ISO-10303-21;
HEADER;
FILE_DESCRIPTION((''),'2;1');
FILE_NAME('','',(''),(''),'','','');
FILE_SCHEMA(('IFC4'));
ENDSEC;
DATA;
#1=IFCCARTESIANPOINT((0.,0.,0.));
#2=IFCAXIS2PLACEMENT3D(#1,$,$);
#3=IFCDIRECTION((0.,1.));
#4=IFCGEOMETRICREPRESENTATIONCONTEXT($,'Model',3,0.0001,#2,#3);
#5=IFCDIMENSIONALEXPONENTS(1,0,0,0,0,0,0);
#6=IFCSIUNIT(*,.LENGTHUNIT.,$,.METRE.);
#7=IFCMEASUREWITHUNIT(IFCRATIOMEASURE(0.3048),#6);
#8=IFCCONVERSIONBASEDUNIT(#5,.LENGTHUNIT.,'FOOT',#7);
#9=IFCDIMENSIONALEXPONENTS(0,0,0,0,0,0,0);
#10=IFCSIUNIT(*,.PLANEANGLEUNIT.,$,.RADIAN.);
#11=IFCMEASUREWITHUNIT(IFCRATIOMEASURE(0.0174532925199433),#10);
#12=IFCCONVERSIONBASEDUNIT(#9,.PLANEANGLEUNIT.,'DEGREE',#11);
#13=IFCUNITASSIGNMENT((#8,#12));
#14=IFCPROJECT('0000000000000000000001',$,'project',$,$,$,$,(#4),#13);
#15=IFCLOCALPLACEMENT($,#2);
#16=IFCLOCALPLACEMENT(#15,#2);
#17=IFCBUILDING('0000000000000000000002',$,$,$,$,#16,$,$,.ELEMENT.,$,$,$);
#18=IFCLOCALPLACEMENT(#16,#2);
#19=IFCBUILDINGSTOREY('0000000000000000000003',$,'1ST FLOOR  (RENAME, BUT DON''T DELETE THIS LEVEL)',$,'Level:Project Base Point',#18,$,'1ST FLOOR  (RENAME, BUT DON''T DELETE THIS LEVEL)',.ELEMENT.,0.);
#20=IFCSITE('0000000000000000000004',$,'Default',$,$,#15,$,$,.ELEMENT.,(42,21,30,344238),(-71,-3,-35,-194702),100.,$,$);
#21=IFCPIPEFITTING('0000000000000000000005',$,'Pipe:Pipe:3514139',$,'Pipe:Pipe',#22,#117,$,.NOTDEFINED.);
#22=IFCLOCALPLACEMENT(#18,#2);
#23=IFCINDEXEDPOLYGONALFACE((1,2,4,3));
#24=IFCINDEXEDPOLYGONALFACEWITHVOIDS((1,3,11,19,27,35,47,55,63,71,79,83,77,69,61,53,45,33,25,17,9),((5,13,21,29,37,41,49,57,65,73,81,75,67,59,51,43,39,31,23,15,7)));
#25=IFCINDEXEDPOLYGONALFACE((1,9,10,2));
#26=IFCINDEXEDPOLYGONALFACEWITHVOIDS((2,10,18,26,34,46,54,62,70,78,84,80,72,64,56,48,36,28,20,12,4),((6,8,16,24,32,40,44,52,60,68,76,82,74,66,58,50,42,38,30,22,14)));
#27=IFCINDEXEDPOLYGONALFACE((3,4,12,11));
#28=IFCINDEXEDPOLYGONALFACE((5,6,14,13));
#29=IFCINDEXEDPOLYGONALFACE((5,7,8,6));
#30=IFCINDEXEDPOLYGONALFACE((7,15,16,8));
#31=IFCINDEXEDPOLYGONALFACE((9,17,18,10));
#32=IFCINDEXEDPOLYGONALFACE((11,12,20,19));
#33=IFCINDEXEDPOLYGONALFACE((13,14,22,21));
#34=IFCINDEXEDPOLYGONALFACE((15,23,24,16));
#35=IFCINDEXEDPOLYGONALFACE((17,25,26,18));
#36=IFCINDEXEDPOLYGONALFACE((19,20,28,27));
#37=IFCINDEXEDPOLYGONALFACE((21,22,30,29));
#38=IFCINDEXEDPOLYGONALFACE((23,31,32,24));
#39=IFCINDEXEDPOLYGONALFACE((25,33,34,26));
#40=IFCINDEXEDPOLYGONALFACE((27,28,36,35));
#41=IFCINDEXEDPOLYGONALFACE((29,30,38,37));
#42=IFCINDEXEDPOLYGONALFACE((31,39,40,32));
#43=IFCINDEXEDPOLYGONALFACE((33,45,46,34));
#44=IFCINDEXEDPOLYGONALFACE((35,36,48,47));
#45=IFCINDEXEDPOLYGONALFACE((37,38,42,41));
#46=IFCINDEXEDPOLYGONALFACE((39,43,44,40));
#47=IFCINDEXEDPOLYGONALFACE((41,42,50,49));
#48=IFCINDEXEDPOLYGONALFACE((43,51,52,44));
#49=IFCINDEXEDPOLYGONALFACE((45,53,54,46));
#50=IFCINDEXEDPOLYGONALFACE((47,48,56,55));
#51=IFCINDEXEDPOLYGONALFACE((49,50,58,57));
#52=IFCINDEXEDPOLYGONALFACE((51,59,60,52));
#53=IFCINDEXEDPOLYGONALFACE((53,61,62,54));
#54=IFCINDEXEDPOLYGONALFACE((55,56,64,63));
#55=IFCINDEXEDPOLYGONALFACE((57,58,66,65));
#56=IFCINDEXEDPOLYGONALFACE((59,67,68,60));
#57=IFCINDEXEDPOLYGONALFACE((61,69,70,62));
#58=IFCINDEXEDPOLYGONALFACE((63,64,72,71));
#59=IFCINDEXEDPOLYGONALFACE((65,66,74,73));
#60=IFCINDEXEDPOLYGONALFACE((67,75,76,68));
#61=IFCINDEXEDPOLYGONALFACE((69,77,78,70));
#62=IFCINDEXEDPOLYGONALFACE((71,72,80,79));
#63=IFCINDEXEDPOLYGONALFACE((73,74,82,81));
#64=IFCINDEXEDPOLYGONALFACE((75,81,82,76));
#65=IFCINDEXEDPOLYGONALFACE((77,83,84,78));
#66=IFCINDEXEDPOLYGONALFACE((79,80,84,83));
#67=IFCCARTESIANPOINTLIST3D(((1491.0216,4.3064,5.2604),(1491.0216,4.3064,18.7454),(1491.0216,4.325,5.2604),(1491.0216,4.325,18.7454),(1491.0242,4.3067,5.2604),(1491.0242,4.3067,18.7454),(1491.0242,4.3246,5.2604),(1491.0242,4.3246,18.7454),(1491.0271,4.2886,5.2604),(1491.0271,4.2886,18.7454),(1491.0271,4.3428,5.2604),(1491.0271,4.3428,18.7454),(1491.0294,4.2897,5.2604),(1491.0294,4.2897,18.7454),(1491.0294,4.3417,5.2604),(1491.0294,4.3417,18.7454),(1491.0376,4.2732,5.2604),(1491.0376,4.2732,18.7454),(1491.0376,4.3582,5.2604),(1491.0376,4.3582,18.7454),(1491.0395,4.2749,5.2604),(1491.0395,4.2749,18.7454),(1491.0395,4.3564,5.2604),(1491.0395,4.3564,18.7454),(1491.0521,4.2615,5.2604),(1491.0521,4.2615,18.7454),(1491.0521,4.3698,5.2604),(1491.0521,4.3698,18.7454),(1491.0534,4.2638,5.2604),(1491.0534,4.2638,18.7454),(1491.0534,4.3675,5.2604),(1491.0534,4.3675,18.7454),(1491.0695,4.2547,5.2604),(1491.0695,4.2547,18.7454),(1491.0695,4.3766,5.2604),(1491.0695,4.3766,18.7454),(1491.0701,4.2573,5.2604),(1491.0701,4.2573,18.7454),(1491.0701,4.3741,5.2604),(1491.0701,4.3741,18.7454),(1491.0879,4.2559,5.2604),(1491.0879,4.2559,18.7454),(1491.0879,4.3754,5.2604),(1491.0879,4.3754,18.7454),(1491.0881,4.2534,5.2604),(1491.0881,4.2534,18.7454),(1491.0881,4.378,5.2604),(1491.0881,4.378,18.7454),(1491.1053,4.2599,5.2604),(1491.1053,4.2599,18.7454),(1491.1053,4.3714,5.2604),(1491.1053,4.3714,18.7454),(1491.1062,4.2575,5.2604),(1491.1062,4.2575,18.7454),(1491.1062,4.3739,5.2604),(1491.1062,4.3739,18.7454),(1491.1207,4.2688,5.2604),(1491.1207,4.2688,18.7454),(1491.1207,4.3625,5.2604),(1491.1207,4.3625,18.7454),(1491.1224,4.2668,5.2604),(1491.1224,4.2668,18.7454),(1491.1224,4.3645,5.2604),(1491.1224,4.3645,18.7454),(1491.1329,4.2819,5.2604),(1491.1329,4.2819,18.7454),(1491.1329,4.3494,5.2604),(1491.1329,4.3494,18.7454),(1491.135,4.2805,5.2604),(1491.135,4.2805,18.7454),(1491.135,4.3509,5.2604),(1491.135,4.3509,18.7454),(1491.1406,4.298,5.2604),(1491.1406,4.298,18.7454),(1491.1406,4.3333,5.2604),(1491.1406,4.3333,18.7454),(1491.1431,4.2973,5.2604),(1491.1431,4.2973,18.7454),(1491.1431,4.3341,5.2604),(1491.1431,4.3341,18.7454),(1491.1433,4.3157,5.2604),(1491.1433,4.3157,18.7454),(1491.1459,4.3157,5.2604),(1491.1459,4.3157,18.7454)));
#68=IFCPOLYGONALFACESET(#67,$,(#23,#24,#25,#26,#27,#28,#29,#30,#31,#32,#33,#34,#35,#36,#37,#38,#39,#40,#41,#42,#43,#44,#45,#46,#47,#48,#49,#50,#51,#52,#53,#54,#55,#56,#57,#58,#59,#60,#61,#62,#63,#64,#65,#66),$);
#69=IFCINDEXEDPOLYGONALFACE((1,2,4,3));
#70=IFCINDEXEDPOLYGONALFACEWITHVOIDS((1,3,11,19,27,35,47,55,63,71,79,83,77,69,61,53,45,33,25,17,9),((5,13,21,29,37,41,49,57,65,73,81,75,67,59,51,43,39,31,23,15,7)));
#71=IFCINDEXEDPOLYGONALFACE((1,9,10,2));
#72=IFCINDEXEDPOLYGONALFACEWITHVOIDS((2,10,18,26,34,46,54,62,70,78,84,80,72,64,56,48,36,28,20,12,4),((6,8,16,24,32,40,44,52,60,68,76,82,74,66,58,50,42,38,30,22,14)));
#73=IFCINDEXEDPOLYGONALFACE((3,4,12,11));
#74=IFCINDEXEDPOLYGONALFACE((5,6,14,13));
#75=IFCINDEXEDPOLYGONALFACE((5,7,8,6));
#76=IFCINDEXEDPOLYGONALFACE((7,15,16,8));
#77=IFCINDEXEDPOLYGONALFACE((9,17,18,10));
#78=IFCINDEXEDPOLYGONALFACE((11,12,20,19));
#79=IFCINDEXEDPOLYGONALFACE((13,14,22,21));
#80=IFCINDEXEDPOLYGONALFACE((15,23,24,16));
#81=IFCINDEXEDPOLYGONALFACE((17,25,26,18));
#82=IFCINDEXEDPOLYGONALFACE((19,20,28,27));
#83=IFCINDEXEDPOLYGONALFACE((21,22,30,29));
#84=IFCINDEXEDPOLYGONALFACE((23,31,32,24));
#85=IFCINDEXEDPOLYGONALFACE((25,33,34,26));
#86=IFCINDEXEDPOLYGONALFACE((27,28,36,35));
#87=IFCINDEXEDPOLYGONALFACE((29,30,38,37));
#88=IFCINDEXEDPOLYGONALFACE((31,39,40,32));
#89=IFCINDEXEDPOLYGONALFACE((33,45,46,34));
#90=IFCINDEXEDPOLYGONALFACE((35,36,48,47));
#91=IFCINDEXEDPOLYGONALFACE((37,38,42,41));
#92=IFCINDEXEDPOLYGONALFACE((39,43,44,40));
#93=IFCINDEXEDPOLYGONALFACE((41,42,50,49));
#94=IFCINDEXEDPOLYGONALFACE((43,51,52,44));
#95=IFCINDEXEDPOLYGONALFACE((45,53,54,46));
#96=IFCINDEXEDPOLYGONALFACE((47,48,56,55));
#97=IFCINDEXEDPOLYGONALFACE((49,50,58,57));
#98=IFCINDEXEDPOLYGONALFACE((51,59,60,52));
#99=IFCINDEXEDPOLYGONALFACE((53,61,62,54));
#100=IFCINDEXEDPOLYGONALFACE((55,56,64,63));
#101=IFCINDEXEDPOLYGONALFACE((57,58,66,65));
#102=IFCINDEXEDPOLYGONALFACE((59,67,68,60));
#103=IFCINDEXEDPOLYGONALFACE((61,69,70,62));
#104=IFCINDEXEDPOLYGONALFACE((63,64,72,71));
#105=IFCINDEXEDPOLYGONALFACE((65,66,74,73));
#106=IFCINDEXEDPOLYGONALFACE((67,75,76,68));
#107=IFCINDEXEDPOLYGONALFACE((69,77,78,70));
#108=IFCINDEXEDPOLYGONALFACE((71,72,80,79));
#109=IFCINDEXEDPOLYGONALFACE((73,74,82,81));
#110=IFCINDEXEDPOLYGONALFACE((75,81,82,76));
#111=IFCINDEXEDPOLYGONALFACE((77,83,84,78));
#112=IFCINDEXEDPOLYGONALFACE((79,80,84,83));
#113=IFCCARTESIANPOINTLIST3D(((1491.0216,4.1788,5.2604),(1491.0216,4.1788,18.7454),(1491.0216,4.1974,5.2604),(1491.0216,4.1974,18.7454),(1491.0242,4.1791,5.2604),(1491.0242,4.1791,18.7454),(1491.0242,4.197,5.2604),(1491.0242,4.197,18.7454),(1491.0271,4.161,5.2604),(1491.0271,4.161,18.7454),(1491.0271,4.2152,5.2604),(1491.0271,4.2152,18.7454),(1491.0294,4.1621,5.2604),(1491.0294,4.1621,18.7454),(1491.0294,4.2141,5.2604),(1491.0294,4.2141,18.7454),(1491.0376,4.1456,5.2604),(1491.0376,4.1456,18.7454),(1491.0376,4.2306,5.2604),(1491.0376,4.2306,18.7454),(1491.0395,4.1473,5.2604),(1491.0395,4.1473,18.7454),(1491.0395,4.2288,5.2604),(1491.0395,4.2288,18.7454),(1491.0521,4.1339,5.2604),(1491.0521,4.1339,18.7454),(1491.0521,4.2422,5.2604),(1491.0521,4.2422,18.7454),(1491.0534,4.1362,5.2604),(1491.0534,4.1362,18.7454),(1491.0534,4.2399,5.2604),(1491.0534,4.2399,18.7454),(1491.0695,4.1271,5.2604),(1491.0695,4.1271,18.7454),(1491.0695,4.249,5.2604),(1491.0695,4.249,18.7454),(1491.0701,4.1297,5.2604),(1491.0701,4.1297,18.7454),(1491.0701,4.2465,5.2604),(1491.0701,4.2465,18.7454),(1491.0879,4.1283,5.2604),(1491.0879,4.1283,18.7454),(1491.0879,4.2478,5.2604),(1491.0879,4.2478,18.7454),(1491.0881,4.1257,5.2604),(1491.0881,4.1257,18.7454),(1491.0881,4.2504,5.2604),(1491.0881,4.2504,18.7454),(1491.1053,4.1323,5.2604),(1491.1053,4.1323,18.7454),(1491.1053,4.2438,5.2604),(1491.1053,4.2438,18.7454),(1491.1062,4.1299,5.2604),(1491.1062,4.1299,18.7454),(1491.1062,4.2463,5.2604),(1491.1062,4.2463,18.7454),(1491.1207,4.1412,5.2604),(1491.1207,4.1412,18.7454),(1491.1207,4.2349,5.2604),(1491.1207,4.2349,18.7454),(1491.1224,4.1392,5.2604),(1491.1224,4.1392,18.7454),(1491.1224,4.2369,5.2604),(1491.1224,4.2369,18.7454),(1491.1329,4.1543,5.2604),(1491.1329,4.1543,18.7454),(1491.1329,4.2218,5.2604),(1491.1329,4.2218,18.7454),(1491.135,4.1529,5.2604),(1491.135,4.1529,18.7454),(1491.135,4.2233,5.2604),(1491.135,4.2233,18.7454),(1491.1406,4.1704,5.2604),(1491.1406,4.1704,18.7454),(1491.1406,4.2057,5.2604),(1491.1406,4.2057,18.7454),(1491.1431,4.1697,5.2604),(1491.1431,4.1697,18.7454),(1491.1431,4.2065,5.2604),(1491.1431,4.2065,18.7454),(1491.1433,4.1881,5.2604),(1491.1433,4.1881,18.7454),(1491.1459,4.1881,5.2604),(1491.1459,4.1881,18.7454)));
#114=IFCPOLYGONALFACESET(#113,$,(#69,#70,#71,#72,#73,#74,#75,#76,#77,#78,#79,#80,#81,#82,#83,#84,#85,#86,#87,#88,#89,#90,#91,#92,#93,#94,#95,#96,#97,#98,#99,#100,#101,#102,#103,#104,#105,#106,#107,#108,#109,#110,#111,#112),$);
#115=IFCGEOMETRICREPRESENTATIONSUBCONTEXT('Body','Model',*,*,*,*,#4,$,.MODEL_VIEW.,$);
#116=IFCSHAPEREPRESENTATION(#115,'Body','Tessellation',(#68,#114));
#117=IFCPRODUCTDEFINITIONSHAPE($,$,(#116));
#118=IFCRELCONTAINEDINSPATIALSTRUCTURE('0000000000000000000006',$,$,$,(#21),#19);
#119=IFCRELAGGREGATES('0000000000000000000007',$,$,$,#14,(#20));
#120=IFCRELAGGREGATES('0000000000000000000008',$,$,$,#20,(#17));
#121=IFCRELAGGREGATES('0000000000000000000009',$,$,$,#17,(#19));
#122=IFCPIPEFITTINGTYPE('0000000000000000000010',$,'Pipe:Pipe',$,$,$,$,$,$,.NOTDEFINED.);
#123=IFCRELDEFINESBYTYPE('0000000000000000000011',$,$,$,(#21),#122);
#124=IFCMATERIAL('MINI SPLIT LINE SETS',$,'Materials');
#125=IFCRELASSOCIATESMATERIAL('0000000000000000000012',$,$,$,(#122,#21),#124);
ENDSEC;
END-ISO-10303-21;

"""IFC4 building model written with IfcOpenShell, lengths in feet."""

from ifc_helpers import new_model, entity, si_unit, converted_unit, direction, frame, origin, origin_2d_with_axis, place, context, subcontext, project, spatial, hollow_circle, extrude, source, transform, mapped, material, type_object, type_shapes, element, save


model = new_model("IFC4")

# Units and contexts
model_context = context("Model", 3, precision=0.0001, world=origin(), true_north=direction((0.0, 1.0)))
body_context = subcontext(model_context, "Body", "Model", "MODEL_VIEW")
ifc_project = project(units=[converted_unit("LENGTHUNIT", "FOOT", entity("IfcRatioMeasure", 0.3048), si_unit("LENGTHUNIT", "METRE"), dimensions=[1, 0, 0, 0, 0, 0, 0]), converted_unit("PLANEANGLEUNIT", "DEGREE", entity("IfcRatioMeasure", 0.0174532925199433), si_unit("PLANEANGLEUNIT", "RADIAN"), dimensions=[0, 0, 0, 0, 0, 0, 0])], contexts=[model_context])

# Site, building, storey
site_placement = place(None, origin())
site = spatial("IfcSite", under=ifc_project, at=site_placement, Name="Default", CompositionType="ELEMENT", RefLatitude=(42, 21, 30, 344238), RefLongitude=(-71, -3, -35, -194702), RefElevation=100.0)
building_placement = place(site_placement, origin())
building = spatial("IfcBuilding", under=site, at=building_placement, CompositionType="ELEMENT")
storey_placement = place(building_placement, origin())
storey = spatial("IfcBuildingStorey", under=building, at=storey_placement, Name="1ST FLOOR  (RENAME, BUT DON'T DELETE THIS LEVEL)", ObjectType="Level:Project Base Point", LongName="1ST FLOOR  (RENAME, BUT DON'T DELETE THIS LEVEL)", CompositionType="ELEMENT", Elevation=0.0)

# Pipe fitting
ifc_material_1 = material(Name="MINI SPLIT LINE SETS", Category="Materials")
pipe_fitting_type_1 = type_object("IfcPipeFittingType", Name="Pipe:Pipe", PredefinedType="NOTDEFINED", material=ifc_material_1)
shared_shape_1 = source(origin(), body_context, "Body", "SweptSolid", [
    extrude(hollow_circle(Radius=0.0625, WallThickness=0.0026, at=origin_2d_with_axis()), frame((0.0677, 0.1953, 0.0)), (0.0, 0.0, 1.0), 13.485),
    extrude(hollow_circle(Radius=0.0625, WallThickness=0.0026, at=origin_2d_with_axis()), frame((0.0677, 0.0677, 0.0)), (0.0, 0.0, 1.0), 13.485),
])
type_shapes(pipe_fitting_type_1, [shared_shape_1])
pipe_fitting_1_placement = place(storey_placement, frame((1491.0157, 4.1203, 5.2604)))
element("IfcPipeFitting", 1, at=pipe_fitting_1_placement, inside=storey, type_object=pipe_fitting_type_1, material=ifc_material_1, Name="Pipe:Pipe:3514139", ObjectType="Pipe:Pipe", PredefinedType="NOTDEFINED", context=body_context, shape_type="MappedRepresentation", body=[
    mapped(shared_shape_1, transform((0.0, 0.0, 0.0), scale=1.0)),
])

save(model, "model.ifc")
